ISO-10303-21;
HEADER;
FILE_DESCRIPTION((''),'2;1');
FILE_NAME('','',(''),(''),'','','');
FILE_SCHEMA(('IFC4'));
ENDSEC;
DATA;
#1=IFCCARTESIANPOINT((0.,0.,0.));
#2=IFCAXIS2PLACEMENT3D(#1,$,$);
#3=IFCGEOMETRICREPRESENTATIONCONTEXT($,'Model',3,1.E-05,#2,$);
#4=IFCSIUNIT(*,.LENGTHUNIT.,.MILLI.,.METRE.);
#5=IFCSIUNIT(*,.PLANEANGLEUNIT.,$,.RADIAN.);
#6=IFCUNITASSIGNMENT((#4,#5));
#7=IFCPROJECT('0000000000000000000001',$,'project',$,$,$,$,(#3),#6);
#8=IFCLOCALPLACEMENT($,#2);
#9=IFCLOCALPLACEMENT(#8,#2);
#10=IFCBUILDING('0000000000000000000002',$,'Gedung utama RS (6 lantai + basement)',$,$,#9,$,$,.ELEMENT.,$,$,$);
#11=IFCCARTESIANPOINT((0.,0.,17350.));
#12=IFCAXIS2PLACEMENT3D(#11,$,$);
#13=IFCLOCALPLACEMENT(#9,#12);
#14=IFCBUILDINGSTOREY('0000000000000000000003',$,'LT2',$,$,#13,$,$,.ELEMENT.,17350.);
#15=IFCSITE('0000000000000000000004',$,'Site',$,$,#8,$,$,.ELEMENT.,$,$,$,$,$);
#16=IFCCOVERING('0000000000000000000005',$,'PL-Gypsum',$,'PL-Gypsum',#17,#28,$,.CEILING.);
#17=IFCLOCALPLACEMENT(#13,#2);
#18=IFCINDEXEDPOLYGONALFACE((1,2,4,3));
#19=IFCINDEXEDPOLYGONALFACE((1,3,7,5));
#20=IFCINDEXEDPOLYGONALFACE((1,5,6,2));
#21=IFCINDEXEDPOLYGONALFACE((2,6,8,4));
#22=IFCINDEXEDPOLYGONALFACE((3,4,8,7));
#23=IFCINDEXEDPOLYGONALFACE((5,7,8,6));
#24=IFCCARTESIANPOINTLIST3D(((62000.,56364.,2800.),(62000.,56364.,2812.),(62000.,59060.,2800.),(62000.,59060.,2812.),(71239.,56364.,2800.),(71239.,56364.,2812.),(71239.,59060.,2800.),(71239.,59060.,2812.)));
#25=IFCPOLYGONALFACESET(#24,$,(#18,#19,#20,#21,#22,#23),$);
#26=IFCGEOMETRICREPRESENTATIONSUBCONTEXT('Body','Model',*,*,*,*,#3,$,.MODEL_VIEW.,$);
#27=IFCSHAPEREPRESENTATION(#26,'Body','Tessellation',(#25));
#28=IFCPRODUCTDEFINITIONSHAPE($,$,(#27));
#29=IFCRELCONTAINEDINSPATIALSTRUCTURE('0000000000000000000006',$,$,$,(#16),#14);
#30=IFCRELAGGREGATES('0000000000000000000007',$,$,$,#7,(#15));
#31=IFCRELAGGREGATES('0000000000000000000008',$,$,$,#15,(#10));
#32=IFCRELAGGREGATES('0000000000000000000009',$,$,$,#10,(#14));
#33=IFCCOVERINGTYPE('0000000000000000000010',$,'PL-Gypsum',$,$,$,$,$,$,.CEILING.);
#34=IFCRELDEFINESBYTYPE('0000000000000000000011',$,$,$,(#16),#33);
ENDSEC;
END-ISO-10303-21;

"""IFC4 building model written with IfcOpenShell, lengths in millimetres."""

from ifc_helpers import new_model, si_unit, frame, origin, place, context, subcontext, project, spatial, polyline, outline, extrude, type_object, element, save


model = new_model("IFC4")

# Units and contexts
model_context = context("Model", 3, precision=1e-05, world=origin())
body_context = subcontext(model_context, "Body", "Model", "MODEL_VIEW")
ifc_project = project(units=[si_unit("LENGTHUNIT", "METRE", prefix="MILLI"), si_unit("PLANEANGLEUNIT", "RADIAN")], contexts=[model_context])

# Site, building, storey
site_placement = place(None, origin())
site = spatial("IfcSite", under=ifc_project, at=site_placement, Name="Site", CompositionType="ELEMENT")
building_placement = place(site_placement, origin())
building = spatial("IfcBuilding", under=site, at=building_placement, Name="Gedung utama RS (6 lantai + basement)", CompositionType="ELEMENT")
storey_placement = place(building_placement, frame((0.0, 0.0, 17350.0)))
storey = spatial("IfcBuildingStorey", under=building, at=storey_placement, Name="LT2", CompositionType="ELEMENT", Elevation=17350.0)

# Covering
covering_type = type_object("IfcCoveringType", Name="PL-Gypsum", PredefinedType="CEILING")
covering_1_placement = place(storey_placement, origin())
element("IfcCovering", 1, at=covering_1_placement, inside=storey, type_object=covering_type, Name="PL-Gypsum", ObjectType="PL-Gypsum", PredefinedType="CEILING", context=body_context, shape_type="SweptSolid", body=[
    extrude(outline(polyline([(62000.0, 56364.0), (71239.0, 56364.0), (71239.0, 59060.0), (62000.0, 59060.0), (62000.0, 56364.0)])), frame((0.0, 0.0, 2800.0)), (0.0, 0.0, 1.0), 12.0),
])

save(model, "model.ifc")
